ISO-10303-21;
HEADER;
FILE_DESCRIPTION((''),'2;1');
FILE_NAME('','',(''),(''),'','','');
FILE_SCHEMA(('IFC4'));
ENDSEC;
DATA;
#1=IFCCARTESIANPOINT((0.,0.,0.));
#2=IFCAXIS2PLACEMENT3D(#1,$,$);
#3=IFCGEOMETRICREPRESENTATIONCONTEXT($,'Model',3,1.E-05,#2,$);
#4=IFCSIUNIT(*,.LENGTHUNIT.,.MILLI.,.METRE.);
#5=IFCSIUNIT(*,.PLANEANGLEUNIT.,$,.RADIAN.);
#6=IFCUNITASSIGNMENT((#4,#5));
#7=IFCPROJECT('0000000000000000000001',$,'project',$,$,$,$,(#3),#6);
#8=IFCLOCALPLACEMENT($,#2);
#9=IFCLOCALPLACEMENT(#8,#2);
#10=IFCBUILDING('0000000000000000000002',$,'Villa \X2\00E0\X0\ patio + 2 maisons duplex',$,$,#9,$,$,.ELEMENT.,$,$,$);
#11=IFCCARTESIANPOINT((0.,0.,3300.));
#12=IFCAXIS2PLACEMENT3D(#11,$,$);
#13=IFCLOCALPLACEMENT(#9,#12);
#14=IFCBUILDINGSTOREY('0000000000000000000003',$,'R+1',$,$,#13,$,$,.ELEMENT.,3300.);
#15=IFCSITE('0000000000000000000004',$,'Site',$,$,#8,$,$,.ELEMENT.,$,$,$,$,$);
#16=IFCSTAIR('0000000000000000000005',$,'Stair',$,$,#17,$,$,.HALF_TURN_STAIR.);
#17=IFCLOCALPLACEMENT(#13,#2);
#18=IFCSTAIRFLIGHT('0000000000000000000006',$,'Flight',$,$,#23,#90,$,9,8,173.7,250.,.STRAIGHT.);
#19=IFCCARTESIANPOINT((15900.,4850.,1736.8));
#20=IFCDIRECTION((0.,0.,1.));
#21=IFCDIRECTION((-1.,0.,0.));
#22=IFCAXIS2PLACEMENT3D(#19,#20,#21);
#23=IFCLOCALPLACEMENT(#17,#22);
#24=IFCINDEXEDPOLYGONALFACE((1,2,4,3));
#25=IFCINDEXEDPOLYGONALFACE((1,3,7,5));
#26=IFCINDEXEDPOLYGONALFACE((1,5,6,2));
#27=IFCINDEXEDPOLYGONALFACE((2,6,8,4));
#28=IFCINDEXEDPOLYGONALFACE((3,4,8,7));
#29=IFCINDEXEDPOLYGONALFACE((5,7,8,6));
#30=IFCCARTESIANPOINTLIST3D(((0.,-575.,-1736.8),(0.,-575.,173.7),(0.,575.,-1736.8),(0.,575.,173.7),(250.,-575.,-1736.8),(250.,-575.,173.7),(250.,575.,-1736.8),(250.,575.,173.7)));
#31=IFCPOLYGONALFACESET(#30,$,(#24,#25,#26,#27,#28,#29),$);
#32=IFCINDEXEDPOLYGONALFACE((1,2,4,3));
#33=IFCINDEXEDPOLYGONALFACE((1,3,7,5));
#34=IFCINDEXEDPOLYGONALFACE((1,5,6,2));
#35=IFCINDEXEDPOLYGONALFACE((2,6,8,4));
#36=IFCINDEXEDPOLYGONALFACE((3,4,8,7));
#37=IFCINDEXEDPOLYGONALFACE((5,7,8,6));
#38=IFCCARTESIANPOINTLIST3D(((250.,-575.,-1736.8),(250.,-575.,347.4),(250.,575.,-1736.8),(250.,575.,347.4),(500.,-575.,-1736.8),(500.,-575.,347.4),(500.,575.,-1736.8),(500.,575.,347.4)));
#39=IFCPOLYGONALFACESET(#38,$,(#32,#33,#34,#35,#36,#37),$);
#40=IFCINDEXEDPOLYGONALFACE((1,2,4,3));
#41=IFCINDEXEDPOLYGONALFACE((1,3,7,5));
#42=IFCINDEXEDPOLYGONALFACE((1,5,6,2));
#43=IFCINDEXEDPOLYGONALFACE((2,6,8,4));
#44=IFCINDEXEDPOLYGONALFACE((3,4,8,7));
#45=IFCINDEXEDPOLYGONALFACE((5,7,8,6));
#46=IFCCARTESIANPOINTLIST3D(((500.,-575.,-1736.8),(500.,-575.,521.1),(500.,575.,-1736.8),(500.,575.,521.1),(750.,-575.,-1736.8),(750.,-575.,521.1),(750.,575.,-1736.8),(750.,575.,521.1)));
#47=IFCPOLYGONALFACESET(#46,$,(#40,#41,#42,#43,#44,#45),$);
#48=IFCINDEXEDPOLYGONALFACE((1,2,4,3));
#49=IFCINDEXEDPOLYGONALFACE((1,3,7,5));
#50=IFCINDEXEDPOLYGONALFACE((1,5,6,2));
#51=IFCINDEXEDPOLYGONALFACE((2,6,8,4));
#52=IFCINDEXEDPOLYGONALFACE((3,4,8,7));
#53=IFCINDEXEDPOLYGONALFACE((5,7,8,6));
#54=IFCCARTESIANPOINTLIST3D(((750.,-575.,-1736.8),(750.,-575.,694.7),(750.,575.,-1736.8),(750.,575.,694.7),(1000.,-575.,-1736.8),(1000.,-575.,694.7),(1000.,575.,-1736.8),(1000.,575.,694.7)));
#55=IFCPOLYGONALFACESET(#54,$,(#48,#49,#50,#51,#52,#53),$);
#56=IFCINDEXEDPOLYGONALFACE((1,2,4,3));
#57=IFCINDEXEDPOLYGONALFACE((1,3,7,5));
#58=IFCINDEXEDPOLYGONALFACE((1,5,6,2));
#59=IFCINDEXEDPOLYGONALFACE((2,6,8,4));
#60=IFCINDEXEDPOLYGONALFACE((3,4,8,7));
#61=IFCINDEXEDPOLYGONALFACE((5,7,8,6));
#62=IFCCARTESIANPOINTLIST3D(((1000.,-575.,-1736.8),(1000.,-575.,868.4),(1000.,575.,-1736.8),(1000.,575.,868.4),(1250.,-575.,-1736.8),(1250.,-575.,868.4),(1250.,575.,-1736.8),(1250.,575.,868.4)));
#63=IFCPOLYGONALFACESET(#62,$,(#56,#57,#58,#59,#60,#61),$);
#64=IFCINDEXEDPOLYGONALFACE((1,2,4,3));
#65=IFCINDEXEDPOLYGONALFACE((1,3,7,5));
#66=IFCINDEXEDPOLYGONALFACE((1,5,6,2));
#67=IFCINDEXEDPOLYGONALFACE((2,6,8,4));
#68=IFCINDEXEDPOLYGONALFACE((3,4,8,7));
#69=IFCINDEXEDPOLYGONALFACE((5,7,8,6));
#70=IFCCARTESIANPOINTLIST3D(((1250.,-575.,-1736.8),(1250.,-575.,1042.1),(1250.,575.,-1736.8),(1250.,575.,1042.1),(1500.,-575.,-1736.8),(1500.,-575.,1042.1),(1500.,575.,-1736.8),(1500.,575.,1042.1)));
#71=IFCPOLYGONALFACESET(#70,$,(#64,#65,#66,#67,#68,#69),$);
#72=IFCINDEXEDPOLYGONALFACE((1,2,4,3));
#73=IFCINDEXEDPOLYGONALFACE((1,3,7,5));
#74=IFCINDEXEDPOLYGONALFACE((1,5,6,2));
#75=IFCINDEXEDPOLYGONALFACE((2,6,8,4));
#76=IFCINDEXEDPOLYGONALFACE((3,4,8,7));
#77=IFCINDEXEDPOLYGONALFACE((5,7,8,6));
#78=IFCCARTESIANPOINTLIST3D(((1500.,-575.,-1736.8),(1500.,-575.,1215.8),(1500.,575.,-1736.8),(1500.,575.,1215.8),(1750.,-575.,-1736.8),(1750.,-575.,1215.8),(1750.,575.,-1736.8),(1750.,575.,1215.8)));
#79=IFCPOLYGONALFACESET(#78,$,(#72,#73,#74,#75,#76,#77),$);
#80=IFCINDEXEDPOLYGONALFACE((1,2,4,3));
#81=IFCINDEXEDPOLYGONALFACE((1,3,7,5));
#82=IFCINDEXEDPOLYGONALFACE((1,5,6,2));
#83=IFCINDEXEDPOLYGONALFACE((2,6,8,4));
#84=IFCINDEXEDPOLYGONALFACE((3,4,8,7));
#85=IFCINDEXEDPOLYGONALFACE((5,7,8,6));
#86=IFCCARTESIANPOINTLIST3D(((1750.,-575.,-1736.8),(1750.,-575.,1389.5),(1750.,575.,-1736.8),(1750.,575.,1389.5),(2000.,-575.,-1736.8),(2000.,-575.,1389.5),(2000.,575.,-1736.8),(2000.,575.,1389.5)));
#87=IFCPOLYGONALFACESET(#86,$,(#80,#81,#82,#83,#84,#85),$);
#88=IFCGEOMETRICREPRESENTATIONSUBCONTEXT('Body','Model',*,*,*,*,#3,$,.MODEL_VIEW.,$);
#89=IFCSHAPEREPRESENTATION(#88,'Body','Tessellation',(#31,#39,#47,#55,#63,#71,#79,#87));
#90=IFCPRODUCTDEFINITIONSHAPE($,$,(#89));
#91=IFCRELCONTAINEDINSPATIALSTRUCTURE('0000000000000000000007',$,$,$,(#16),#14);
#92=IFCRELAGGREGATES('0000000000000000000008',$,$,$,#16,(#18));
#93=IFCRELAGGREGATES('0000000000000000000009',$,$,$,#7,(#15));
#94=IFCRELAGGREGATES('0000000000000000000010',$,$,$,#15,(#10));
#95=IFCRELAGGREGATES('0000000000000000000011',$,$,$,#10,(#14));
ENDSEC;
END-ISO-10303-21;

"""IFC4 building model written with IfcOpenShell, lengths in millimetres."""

from ifc_helpers import new_model, si_unit, frame, frame_2d, origin, place, context, subcontext, project, spatial, rectangle, extrude, element, aggregate, save


model = new_model("IFC4")

# Units and contexts
model_context = context("Model", 3, precision=1e-05, world=origin())
body_context = subcontext(model_context, "Body", "Model", "MODEL_VIEW")
ifc_project = project(units=[si_unit("LENGTHUNIT", "METRE", prefix="MILLI"), si_unit("PLANEANGLEUNIT", "RADIAN")], contexts=[model_context])

# Site, building, storey
site_placement = place(None, origin())
site = spatial("IfcSite", under=ifc_project, at=site_placement, Name="Site", CompositionType="ELEMENT")
building_placement = place(site_placement, origin())
building = spatial("IfcBuilding", under=site, at=building_placement, Name="Villa à patio + 2 maisons duplex", CompositionType="ELEMENT")
storey_placement = place(building_placement, frame((0.0, 0.0, 3300.0)))
storey = spatial("IfcBuildingStorey", under=building, at=storey_placement, Name="R+1", CompositionType="ELEMENT", Elevation=3300.0)

# Stair, stair flight
stair_1_placement = place(storey_placement, origin())
stair_1 = element("IfcStair", 1, at=stair_1_placement, inside=storey, Name="Stair", PredefinedType="HALF_TURN_STAIR")
stair_flight_1_placement = place(stair_1_placement, frame((15900.0, 4850.0, 1736.8), z_axis=(0.0, 0.0, 1.0), x_axis=(-1.0, 0.0, 0.0)))
stair_flight_1 = element("IfcStairFlight", 2, at=stair_flight_1_placement, Name="Flight", NumberOfRisers=9, NumberOfTreads=8, PredefinedType="STRAIGHT", RiserHeight=173.7, TreadLength=250.0, context=body_context, shape_type="SweptSolid", body=[
    extrude(rectangle(XDim=250.0, YDim=1150.0, at=frame_2d((125.0, 0.0))), frame((0.0, 0.0, -1736.8)), (0.0, 0.0, 1.0), 1910.5),
    extrude(rectangle(XDim=250.0, YDim=1150.0, at=frame_2d((375.0, 0.0))), frame((0.0, 0.0, -1736.8)), (0.0, 0.0, 1.0), 2084.2),
    extrude(rectangle(XDim=250.0, YDim=1150.0, at=frame_2d((625.0, 0.0))), frame((0.0, 0.0, -1736.8)), (0.0, 0.0, 1.0), 2257.9),
    extrude(rectangle(XDim=250.0, YDim=1150.0, at=frame_2d((875.0, 0.0))), frame((0.0, 0.0, -1736.8)), (0.0, 0.0, 1.0), 2431.6),
    extrude(rectangle(XDim=250.0, YDim=1150.0, at=frame_2d((1125.0, 0.0))), frame((0.0, 0.0, -1736.8)), (0.0, 0.0, 1.0), 2605.3),
    extrude(rectangle(XDim=250.0, YDim=1150.0, at=frame_2d((1375.0, 0.0))), frame((0.0, 0.0, -1736.8)), (0.0, 0.0, 1.0), 2778.9),
    extrude(rectangle(XDim=250.0, YDim=1150.0, at=frame_2d((1625.0, 0.0))), frame((0.0, 0.0, -1736.8)), (0.0, 0.0, 1.0), 2952.6),
    extrude(rectangle(XDim=250.0, YDim=1150.0, at=frame_2d((1875.0, 0.0))), frame((0.0, 0.0, -1736.8)), (0.0, 0.0, 1.0), 3126.3),
])
aggregate(stair_1, [stair_flight_1])

save(model, "model.ifc")
